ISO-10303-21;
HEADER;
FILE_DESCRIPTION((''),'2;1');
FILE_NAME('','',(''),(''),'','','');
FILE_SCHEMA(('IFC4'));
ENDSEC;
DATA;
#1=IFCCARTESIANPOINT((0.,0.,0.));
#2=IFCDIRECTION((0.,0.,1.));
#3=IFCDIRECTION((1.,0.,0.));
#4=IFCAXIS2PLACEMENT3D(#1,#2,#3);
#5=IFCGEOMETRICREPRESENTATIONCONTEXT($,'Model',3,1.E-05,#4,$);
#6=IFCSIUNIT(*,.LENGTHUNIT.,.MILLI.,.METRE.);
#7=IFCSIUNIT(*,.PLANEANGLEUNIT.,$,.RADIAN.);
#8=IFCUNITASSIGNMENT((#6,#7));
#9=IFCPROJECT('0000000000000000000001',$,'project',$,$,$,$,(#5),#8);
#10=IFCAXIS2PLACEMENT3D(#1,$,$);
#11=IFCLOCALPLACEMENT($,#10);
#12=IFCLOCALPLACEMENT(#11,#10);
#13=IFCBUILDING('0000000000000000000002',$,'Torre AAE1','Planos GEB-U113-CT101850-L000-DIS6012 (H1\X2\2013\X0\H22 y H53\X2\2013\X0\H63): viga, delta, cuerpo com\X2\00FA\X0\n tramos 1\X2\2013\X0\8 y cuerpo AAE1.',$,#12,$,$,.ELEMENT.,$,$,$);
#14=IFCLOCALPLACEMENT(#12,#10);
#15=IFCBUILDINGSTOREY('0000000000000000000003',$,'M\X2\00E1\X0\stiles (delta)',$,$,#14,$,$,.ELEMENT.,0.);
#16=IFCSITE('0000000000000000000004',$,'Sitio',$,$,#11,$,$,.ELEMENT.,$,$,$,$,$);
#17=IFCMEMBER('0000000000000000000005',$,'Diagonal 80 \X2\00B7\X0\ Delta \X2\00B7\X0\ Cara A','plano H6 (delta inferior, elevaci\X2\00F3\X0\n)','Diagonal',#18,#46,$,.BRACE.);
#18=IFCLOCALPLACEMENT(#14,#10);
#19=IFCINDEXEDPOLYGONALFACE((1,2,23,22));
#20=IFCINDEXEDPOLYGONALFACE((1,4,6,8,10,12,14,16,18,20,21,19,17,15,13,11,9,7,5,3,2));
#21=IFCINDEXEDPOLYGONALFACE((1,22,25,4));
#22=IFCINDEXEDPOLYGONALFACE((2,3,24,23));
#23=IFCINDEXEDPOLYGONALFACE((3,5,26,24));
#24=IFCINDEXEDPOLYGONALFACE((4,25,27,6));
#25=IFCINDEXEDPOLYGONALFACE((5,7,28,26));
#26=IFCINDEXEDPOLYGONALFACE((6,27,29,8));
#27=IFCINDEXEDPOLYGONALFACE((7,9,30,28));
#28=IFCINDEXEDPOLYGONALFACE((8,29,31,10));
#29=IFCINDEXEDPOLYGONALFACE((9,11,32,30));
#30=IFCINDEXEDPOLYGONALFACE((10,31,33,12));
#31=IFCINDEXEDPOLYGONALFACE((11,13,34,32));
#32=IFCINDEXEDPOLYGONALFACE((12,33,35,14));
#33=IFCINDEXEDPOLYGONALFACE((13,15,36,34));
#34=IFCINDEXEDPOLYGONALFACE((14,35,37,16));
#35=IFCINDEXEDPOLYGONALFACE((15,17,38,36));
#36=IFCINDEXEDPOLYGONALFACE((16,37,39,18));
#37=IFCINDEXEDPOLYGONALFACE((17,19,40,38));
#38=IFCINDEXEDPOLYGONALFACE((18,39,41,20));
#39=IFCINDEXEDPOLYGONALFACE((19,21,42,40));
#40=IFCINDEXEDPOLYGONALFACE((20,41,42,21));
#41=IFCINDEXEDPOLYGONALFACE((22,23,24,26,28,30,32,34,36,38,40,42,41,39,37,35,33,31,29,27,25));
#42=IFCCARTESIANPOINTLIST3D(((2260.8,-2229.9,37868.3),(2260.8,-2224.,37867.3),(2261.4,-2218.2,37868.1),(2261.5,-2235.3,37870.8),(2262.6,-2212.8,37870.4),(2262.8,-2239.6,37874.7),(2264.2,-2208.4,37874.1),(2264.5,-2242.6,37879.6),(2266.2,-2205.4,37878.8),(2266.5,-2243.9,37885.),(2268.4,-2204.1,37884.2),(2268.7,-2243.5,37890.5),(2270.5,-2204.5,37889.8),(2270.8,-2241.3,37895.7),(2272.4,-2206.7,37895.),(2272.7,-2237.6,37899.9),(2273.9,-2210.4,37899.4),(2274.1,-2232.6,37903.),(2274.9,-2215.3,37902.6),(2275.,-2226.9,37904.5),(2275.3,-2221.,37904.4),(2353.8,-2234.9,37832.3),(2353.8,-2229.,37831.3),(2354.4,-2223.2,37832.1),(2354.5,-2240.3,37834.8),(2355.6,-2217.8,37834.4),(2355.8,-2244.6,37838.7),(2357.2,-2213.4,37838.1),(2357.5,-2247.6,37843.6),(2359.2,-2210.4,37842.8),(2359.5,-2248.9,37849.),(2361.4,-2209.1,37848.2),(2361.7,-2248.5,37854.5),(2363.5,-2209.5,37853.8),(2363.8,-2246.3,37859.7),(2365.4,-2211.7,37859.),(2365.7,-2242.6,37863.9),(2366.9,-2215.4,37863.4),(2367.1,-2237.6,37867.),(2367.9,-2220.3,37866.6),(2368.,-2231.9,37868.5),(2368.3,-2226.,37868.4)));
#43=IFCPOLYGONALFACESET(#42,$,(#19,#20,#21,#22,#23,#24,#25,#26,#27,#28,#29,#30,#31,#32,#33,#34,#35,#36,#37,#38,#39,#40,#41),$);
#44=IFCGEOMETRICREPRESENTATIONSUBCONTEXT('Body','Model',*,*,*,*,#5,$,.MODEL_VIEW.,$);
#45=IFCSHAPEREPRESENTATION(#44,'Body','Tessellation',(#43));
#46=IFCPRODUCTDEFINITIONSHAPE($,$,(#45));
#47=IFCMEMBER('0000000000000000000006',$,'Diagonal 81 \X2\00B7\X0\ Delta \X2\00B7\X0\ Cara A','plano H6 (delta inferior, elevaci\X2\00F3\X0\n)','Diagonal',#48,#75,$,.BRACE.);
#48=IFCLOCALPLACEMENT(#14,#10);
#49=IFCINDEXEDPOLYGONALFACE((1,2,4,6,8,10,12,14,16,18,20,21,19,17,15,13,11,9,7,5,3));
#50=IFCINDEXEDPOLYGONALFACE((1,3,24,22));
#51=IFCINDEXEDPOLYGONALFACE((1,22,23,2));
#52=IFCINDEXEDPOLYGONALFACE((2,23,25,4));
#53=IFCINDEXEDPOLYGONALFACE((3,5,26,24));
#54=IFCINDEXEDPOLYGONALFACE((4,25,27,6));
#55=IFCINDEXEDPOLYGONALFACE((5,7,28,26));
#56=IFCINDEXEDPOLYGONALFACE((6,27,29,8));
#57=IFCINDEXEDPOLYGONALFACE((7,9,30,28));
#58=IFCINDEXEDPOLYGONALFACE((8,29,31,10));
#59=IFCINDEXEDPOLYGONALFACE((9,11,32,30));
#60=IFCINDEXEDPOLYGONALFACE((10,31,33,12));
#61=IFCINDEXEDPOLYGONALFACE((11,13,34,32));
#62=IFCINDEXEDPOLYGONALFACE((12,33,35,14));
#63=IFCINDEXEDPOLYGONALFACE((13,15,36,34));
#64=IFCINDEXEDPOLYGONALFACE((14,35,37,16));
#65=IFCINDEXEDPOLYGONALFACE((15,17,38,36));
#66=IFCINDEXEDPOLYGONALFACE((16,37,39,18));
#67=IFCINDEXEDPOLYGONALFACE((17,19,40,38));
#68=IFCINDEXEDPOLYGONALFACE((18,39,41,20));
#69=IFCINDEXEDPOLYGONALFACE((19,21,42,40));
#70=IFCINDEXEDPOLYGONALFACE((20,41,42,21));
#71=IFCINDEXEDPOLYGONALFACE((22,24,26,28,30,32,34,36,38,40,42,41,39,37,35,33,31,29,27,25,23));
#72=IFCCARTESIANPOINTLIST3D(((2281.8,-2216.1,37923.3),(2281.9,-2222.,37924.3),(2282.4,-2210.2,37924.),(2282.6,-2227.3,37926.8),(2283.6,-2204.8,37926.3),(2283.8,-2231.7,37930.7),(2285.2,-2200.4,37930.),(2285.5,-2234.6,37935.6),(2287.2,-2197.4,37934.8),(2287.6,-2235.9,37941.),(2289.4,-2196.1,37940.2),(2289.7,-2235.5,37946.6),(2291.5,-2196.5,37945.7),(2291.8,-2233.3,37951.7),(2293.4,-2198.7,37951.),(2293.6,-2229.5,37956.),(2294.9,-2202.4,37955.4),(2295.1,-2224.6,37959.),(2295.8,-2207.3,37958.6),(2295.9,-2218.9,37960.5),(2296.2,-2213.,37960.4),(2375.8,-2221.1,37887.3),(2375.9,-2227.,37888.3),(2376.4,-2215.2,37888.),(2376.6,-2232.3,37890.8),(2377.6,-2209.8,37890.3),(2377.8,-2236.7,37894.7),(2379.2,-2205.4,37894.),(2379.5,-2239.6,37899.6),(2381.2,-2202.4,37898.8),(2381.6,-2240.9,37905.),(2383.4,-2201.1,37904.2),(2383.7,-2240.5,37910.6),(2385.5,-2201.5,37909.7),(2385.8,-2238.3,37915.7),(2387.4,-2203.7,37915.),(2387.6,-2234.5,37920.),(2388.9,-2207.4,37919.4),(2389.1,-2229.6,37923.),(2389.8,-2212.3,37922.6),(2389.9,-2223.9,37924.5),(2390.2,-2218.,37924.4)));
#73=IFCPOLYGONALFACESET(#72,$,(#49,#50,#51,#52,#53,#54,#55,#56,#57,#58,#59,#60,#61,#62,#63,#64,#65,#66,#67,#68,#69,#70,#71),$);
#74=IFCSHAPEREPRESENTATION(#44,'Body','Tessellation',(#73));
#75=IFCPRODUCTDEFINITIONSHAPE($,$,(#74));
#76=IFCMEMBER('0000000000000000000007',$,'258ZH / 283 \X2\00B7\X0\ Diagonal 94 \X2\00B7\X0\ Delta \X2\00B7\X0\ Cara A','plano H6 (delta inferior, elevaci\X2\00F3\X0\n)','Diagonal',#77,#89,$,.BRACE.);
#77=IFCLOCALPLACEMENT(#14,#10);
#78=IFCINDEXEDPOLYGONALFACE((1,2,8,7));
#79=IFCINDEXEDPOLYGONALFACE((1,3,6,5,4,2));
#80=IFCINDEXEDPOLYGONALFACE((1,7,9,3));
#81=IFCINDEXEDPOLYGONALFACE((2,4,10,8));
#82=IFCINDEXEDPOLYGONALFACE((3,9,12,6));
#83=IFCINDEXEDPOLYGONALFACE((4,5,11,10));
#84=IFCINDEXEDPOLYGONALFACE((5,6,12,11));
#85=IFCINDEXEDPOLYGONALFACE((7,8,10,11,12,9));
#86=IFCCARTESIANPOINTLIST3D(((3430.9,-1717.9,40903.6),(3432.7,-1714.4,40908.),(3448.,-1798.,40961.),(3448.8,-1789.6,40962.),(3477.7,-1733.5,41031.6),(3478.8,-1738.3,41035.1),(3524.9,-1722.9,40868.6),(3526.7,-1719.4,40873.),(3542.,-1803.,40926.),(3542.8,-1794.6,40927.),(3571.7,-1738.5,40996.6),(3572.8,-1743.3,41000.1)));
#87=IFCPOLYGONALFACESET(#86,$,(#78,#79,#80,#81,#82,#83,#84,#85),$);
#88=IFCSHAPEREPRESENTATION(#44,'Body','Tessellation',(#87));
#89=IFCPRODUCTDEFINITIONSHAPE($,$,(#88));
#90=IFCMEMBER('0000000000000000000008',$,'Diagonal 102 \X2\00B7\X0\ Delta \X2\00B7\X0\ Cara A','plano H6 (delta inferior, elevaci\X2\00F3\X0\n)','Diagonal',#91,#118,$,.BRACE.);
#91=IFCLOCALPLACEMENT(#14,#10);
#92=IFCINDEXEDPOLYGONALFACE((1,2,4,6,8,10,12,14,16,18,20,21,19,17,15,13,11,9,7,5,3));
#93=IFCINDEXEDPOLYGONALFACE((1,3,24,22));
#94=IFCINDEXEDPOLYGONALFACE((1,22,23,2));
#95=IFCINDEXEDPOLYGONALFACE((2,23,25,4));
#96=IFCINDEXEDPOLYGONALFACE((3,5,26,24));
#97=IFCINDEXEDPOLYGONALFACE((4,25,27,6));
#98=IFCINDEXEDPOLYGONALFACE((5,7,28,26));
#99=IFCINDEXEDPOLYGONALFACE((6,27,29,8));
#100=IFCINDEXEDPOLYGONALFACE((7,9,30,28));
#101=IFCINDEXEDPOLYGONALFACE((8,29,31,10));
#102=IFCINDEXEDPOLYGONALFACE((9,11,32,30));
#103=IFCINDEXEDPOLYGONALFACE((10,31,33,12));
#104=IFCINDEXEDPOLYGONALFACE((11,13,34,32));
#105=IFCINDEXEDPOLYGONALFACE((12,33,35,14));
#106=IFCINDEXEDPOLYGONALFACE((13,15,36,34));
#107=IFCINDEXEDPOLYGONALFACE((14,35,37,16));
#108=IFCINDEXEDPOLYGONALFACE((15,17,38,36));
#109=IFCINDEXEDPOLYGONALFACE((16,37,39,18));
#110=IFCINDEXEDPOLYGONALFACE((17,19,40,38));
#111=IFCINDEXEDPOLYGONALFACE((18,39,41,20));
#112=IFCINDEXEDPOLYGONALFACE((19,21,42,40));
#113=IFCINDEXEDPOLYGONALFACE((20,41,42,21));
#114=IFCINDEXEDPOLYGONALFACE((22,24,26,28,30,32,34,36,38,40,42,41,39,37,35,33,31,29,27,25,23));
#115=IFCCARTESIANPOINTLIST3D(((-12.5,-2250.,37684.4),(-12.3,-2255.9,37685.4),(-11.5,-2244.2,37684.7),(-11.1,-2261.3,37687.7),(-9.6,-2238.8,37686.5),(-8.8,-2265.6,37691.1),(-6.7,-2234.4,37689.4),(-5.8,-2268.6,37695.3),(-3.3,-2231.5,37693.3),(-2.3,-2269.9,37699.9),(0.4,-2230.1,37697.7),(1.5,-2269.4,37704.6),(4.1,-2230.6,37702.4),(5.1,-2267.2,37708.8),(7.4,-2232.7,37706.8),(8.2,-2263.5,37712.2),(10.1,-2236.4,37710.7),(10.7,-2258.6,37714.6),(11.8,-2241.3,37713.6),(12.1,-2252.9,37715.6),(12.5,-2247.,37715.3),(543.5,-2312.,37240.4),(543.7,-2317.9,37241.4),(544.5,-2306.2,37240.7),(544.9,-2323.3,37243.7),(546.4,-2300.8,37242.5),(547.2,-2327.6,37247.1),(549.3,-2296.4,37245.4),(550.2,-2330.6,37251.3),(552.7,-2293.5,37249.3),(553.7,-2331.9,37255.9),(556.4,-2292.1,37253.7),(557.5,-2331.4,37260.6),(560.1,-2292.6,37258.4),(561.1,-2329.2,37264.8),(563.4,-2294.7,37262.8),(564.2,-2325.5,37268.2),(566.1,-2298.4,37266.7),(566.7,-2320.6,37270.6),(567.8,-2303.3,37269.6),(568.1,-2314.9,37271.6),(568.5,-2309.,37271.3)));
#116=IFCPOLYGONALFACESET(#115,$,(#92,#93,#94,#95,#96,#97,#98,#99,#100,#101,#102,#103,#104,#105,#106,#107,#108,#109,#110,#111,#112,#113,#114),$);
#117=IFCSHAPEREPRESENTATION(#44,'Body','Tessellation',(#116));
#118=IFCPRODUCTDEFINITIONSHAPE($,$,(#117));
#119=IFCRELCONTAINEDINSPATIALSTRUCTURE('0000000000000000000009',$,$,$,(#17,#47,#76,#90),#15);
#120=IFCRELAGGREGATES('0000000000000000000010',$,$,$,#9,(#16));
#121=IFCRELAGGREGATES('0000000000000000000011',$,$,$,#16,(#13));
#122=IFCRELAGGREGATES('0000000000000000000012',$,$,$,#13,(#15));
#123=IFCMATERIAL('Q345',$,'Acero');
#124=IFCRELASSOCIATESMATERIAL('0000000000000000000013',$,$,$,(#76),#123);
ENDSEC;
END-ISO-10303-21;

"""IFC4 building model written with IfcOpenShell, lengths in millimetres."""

from ifc_helpers import new_model, si_unit, frame, frame_2d, origin, origin_with_axes, place, context, subcontext, project, spatial, circle, l_section, extrude, material, element, save


model = new_model("IFC4")

# Units and contexts
model_context = context("Model", 3, precision=1e-05, world=origin_with_axes())
body_context = subcontext(model_context, "Body", "Model", "MODEL_VIEW")
ifc_project = project(units=[si_unit("LENGTHUNIT", "METRE", prefix="MILLI"), si_unit("PLANEANGLEUNIT", "RADIAN")], contexts=[model_context])

# Site, building, storey
site_placement = place(None, origin())
site = spatial("IfcSite", under=ifc_project, at=site_placement, Name="Sitio", CompositionType="ELEMENT")
building_placement = place(site_placement, origin())
building = spatial("IfcBuilding", under=site, at=building_placement, Name="Torre AAE1", Description="Planos GEB-U113-CT101850-L000-DIS6012 (H1–H22 y H53–H63): viga, delta, cuerpo común tramos 1–8 y cuerpo AAE1.", CompositionType="ELEMENT")
storey_placement = place(building_placement, origin())
storey = spatial("IfcBuildingStorey", under=building, at=storey_placement, Name="Mástiles (delta)", CompositionType="ELEMENT", Elevation=0.0)

# Members
ifc_material_1 = material(Name="Q345", Category="Acero")
member_1_placement = place(storey_placement, frame((2361.0, -2229.0, 37850.0), z_axis=(-0.931398, 0.050075, 0.360541), x_axis=(-0.089167, 0.928927, -0.359365)))
element("IfcMember", 1, at=member_1_placement, inside=storey, Name="Diagonal 80 · Delta · Cara A", Description="plano H6 (delta inferior, elevación)", ObjectType="Diagonal", PredefinedType="BRACE", context=body_context, shape_type="SweptSolid", body=[
    extrude(circle(Radius=20.0), None, (0.0, 0.0, 1.0), 99.8),
])
member_2_placement = place(storey_placement, frame((2383.0, -2221.0, 37906.0), z_axis=(-0.932707, 0.049612, 0.357207), x_axis=(-0.088729, 0.928476, -0.360637)))
element("IfcMember", 2, at=member_2_placement, inside=storey, Name="Diagonal 81 · Delta · Cara A", Description="plano H6 (delta inferior, elevación)", ObjectType="Diagonal", PredefinedType="BRACE", context=body_context, shape_type="SweptSolid", body=[
    extrude(circle(Radius=20.0), None, (0.0, 0.0, 1.0), 100.8),
])
member_3_placement = place(storey_placement, frame((3448.0, -1798.0, 40961.0), z_axis=(0.935984, -0.049786, -0.348505), x_axis=(-0.171209, 0.800618, -0.574193)))
element("IfcMember", 3, at=member_3_placement, inside=storey, material=ifc_material_1, Name="258ZH / 283 · Diagonal 94 · Delta · Cara A", Description="plano H6 (delta inferior, elevación)", ObjectType="Diagonal", PredefinedType="BRACE", context=body_context, shape_type="SweptSolid", body=[
    extrude(l_section(Depth=100.0, Width=100.0, Thickness=6.0, at=frame_2d((50.0, 50.0))), None, (0.0, 0.0, 1.0), 100.4),
])
member_4_placement = place(storey_placement, frame((0.0, -2250.0, 37700.0), z_axis=(0.778467, -0.086807, -0.621654), x_axis=(0.019739, 0.993286, -0.113984)))
element("IfcMember", 4, at=member_4_placement, inside=storey, Name="Diagonal 102 · Delta · Cara A", Description="plano H6 (delta inferior, elevación)", ObjectType="Diagonal", PredefinedType="BRACE", context=body_context, shape_type="SweptSolid", body=[
    extrude(circle(Radius=20.0), None, (0.0, 0.0, 1.0), 714.2),
])

save(model, "model.ifc")
